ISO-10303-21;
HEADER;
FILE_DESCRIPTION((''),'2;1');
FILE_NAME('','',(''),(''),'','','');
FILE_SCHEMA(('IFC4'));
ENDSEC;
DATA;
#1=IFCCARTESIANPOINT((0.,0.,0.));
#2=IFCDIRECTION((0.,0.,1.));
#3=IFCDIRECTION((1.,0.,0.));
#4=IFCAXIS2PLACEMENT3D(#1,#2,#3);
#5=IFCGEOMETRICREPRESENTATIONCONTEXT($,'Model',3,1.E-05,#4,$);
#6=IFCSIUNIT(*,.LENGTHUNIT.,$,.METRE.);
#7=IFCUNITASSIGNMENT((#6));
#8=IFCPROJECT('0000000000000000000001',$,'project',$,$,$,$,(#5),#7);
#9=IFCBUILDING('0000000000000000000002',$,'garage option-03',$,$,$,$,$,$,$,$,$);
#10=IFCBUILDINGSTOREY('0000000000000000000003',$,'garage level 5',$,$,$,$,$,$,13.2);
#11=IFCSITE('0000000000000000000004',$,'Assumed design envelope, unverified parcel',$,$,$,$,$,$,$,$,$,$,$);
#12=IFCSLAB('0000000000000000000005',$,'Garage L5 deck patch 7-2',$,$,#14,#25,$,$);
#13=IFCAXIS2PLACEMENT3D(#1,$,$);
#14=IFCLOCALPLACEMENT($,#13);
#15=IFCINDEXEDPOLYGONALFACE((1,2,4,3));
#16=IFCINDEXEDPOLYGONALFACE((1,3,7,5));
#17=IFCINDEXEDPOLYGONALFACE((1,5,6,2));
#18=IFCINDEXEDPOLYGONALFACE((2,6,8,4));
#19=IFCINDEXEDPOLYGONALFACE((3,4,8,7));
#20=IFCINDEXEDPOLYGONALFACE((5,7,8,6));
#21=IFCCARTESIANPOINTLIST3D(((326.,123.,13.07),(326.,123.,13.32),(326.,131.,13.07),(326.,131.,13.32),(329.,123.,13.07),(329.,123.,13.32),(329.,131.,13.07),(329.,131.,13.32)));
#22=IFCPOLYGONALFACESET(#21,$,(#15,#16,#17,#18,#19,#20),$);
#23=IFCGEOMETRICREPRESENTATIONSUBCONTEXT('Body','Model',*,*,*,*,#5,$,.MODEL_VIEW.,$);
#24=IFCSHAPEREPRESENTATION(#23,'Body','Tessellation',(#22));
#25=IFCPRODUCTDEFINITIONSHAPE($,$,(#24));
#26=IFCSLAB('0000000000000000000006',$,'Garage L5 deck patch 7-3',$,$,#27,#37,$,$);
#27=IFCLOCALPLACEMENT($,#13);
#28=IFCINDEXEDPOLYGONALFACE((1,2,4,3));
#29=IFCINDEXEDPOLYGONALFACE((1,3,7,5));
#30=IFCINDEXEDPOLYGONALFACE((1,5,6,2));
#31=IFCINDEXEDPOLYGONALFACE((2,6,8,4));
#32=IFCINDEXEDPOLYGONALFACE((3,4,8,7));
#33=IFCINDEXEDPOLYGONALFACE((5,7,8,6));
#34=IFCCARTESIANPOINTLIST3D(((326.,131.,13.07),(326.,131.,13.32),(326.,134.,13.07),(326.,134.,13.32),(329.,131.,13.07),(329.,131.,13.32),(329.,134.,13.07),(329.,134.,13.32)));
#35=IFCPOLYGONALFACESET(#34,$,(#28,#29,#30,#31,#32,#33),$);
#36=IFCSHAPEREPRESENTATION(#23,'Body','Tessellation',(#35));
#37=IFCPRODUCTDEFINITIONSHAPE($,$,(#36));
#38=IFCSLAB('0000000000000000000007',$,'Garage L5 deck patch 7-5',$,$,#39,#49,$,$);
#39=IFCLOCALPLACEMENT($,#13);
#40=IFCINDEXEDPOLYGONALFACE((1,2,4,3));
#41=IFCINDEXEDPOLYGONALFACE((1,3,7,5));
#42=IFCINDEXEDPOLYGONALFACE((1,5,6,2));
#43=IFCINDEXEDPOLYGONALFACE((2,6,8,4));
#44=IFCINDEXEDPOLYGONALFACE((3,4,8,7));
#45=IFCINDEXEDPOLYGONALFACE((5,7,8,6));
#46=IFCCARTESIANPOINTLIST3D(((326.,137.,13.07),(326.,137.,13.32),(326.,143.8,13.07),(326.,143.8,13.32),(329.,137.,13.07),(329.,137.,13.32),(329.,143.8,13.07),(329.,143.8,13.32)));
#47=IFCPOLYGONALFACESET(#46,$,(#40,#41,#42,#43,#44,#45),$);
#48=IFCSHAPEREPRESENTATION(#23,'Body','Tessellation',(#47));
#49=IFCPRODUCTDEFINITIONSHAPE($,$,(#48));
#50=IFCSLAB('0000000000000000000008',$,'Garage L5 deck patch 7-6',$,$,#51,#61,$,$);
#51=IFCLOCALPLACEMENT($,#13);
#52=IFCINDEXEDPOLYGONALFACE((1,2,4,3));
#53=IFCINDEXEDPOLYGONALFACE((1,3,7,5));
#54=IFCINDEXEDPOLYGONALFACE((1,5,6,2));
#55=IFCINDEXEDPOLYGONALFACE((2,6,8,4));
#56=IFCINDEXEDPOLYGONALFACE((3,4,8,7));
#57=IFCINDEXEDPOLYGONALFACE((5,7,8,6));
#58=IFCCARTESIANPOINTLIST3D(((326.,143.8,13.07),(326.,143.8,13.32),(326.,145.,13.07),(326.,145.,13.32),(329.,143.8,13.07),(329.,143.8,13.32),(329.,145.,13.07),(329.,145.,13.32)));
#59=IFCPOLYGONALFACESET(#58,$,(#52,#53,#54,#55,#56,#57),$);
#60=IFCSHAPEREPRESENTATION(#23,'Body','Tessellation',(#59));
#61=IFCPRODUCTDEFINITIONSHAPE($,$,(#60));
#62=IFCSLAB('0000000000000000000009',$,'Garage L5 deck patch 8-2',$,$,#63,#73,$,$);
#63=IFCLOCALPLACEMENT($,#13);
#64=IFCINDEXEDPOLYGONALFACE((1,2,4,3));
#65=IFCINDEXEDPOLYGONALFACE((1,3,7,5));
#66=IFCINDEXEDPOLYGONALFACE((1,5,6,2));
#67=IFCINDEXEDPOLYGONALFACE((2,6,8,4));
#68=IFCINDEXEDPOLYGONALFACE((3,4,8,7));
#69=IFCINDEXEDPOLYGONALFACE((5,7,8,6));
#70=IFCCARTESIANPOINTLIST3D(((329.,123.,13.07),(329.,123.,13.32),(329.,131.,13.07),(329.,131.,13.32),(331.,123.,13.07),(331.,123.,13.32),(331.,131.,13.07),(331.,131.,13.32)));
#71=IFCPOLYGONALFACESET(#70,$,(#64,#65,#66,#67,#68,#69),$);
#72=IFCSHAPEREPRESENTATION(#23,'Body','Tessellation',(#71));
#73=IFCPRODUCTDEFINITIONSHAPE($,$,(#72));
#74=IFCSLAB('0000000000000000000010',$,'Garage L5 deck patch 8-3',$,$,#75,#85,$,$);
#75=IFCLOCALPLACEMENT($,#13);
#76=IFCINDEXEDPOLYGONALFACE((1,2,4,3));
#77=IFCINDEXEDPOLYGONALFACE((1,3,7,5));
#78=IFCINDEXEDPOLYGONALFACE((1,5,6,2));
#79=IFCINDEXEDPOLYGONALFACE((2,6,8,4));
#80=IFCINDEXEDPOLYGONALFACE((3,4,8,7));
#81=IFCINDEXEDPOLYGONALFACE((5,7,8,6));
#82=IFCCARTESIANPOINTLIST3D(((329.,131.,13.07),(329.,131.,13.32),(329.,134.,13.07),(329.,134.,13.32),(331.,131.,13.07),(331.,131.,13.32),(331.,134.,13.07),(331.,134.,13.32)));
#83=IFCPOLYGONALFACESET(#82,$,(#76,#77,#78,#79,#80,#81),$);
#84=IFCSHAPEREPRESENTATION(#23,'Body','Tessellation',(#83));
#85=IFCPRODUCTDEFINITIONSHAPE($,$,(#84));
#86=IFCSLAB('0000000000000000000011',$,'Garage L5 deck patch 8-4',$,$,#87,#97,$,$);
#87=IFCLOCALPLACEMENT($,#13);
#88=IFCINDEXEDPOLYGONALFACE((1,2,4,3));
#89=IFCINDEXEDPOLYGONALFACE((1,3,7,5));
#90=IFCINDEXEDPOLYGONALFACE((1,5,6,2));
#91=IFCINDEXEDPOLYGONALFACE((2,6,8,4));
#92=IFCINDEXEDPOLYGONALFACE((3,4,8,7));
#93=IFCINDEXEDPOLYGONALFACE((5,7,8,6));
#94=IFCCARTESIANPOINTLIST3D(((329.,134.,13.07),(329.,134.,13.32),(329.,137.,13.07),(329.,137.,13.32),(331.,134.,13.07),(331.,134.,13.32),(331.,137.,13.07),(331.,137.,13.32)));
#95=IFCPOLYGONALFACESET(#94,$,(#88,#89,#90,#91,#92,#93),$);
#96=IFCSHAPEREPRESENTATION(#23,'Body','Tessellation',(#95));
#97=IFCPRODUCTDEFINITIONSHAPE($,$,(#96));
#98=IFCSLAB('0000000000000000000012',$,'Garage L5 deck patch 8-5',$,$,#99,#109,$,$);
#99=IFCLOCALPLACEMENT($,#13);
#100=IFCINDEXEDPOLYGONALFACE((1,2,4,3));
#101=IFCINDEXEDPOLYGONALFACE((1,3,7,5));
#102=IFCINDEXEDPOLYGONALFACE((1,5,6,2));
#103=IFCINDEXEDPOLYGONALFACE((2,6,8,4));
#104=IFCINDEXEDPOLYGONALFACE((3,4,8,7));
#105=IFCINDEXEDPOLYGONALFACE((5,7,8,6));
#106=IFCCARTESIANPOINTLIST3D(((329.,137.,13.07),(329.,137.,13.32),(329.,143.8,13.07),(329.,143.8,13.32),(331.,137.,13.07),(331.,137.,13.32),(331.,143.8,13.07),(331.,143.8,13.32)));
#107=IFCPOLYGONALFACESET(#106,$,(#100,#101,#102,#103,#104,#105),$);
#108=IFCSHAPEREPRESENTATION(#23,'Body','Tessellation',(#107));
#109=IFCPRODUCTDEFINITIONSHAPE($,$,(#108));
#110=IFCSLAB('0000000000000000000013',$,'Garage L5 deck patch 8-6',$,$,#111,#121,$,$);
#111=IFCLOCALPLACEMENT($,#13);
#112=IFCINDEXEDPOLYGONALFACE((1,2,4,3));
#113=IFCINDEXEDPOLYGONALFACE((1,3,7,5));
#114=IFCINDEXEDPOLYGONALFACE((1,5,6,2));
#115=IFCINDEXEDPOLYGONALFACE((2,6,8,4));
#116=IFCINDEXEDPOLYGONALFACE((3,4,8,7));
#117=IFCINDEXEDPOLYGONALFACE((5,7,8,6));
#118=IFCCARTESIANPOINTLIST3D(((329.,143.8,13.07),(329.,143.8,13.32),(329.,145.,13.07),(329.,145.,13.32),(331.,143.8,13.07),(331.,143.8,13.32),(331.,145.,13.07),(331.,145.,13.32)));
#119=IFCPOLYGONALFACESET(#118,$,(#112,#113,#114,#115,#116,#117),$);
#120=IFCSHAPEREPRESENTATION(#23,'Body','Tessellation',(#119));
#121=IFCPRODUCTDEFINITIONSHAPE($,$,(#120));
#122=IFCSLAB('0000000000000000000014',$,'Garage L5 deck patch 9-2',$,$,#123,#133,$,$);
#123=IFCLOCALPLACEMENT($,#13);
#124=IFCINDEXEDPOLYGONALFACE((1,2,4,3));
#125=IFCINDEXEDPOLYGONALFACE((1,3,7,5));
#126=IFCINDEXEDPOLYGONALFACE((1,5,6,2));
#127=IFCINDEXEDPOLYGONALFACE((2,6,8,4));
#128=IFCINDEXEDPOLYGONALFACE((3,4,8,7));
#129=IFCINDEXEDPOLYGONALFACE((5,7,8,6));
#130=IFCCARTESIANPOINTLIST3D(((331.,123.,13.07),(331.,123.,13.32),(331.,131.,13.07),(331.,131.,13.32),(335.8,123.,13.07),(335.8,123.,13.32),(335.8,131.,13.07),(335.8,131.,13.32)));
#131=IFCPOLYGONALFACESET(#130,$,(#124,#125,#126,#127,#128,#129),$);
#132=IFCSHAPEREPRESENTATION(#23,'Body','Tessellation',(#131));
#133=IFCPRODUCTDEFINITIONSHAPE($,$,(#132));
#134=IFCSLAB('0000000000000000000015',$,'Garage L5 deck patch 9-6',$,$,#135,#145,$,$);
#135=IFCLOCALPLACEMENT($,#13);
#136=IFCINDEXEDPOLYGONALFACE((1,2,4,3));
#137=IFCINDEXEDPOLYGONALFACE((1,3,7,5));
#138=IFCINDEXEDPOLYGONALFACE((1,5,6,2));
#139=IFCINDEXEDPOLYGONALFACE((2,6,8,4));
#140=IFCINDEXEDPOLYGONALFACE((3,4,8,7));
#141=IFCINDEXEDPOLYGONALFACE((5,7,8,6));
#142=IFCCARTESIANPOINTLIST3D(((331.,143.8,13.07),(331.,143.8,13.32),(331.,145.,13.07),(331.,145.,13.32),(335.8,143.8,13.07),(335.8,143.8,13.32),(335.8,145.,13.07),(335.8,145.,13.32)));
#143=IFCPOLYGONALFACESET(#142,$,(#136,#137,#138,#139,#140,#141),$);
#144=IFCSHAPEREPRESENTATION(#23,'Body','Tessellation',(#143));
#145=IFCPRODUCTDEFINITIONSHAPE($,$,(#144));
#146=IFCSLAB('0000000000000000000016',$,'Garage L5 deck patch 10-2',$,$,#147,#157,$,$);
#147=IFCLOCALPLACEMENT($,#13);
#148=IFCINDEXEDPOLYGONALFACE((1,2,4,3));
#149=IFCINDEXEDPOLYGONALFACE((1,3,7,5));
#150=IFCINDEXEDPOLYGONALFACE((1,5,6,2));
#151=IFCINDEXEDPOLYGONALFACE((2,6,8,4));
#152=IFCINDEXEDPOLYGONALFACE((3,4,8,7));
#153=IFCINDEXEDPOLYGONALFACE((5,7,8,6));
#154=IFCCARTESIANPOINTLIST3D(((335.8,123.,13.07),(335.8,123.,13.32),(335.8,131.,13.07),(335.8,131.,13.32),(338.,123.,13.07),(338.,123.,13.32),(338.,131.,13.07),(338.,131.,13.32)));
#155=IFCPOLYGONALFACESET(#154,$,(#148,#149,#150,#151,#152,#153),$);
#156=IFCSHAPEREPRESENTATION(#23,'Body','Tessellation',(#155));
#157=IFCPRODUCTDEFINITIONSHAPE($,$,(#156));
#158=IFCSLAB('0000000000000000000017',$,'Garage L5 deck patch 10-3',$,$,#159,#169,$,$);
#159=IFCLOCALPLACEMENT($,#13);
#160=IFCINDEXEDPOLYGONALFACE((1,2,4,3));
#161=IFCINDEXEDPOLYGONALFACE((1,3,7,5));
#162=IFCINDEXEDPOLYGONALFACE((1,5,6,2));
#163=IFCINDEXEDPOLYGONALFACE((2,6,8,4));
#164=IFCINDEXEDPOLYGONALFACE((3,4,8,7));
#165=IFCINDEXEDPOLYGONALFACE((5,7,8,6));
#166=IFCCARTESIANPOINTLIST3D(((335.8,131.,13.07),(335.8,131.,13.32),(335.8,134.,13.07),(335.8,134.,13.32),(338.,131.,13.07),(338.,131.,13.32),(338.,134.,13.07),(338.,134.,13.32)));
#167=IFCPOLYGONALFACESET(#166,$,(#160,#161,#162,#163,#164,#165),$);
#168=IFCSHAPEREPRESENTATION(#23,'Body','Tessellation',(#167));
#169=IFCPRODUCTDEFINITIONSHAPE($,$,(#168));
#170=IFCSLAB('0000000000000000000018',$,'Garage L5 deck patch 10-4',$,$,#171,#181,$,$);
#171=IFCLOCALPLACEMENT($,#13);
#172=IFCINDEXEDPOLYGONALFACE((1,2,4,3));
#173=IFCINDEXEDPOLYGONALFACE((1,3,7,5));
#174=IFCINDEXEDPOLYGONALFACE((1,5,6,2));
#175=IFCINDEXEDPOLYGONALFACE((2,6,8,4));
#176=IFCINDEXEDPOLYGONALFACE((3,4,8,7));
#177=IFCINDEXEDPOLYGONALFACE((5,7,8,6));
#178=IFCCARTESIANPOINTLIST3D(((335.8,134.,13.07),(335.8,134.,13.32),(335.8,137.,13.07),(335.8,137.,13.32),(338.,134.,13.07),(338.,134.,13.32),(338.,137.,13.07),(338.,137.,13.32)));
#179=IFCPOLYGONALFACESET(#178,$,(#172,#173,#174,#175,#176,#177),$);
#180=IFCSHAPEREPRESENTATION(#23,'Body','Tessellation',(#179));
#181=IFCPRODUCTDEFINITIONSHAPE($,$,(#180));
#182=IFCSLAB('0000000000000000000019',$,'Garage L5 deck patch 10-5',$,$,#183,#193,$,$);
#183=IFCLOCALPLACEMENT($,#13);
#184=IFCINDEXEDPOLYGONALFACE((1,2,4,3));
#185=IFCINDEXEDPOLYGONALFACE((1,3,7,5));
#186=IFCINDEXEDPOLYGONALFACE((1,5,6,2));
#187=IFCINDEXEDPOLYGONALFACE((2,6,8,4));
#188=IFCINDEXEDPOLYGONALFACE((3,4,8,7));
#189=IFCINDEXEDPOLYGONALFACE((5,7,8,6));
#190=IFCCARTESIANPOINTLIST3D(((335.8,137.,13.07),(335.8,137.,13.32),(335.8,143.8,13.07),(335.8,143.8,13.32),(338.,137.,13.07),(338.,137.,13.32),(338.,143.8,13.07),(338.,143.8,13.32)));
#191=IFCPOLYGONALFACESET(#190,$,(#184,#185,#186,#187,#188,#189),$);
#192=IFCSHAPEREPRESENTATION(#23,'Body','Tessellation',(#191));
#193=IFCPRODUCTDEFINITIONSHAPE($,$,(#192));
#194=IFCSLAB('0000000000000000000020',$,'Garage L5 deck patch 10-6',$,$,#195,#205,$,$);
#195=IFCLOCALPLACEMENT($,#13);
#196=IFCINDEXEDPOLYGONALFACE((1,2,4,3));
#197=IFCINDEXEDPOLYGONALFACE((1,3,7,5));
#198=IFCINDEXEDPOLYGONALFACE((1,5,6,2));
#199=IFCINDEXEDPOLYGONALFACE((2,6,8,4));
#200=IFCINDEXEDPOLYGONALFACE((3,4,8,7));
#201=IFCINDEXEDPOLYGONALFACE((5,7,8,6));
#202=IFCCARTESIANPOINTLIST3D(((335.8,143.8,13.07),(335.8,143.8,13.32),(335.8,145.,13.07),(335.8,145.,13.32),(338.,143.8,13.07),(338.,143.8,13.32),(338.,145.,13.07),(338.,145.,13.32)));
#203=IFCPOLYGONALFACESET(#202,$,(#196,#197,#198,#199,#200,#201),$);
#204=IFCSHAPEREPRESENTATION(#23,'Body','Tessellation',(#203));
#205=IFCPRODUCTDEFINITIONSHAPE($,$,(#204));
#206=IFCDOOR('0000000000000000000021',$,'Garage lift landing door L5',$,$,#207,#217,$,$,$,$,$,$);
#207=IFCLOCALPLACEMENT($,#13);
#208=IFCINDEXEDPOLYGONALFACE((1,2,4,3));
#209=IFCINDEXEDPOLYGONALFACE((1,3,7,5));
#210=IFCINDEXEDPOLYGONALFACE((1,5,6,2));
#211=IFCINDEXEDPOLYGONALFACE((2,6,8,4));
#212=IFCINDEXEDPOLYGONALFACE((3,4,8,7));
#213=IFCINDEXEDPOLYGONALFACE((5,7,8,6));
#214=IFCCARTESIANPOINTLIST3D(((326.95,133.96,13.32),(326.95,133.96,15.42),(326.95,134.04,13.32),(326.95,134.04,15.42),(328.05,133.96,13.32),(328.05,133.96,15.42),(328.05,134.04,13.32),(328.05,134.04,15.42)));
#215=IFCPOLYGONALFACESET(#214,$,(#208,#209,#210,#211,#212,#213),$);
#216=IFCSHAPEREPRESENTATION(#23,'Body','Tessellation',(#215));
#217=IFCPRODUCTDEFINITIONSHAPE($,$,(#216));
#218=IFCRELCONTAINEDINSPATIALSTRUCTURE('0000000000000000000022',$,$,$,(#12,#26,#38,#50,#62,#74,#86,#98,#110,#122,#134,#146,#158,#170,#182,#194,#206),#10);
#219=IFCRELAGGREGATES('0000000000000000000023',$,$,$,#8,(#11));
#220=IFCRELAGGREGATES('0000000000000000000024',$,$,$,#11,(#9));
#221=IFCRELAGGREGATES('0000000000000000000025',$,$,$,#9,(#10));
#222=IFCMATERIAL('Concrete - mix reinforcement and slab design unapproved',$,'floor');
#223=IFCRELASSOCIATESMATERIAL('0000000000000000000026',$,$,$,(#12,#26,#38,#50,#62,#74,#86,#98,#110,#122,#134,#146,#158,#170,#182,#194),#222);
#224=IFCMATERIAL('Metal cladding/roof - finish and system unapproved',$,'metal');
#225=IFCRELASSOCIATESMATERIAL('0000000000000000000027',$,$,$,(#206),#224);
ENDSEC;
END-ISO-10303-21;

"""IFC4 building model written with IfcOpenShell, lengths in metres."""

from ifc_helpers import new_model, si_unit, frame, origin_with_axes, place, context, subcontext, project, spatial, rectangle, extrude, material, element, save


model = new_model("IFC4")

# Units and contexts
model_context = context("Model", 3, precision=1e-05, world=origin_with_axes())
body_context = subcontext(model_context, "Body", "Model", "MODEL_VIEW")
ifc_project = project(units=[si_unit("LENGTHUNIT", "METRE")], contexts=[model_context])

# Site, building, storey
site = spatial("IfcSite", under=ifc_project, Name="Assumed design envelope, unverified parcel")
building = spatial("IfcBuilding", under=site, Name="garage option-03")
storey = spatial("IfcBuildingStorey", under=building, Name="garage level 5", Elevation=13.2)

# Slabs
ifc_material_1 = material(Name="Concrete - mix reinforcement and slab design unapproved", Category="floor")
slab_1_placement = place(None, frame((327.5, 127.0, 13.07), z_axis=(0.0, 0.0, 1.0), x_axis=(1.0, 0.0, 0.0)))
element("IfcSlab", 1, at=slab_1_placement, inside=storey, material=ifc_material_1, Name="Garage L5 deck patch 7-2", context=body_context, shape_type="SweptSolid", body=[
    extrude(rectangle(XDim=3.0, YDim=8.0), origin_with_axes(), (0.0, 0.0, 1.0), 0.25),
])
slab_2_placement = place(None, frame((327.5, 132.5, 13.07), z_axis=(0.0, 0.0, 1.0), x_axis=(1.0, 0.0, 0.0)))
element("IfcSlab", 2, at=slab_2_placement, inside=storey, material=ifc_material_1, Name="Garage L5 deck patch 7-3", context=body_context, shape_type="SweptSolid", body=[
    extrude(rectangle(XDim=3.0, YDim=3.0), origin_with_axes(), (0.0, 0.0, 1.0), 0.25),
])
slab_3_placement = place(None, frame((327.5, 140.4, 13.07), z_axis=(0.0, 0.0, 1.0), x_axis=(1.0, 0.0, 0.0)))
element("IfcSlab", 3, at=slab_3_placement, inside=storey, material=ifc_material_1, Name="Garage L5 deck patch 7-5", context=body_context, shape_type="SweptSolid", body=[
    extrude(rectangle(XDim=3.0, YDim=6.8), origin_with_axes(), (0.0, 0.0, 1.0), 0.25),
])
slab_4_placement = place(None, frame((327.5, 144.4, 13.07), z_axis=(0.0, 0.0, 1.0), x_axis=(1.0, 0.0, 0.0)))
element("IfcSlab", 4, at=slab_4_placement, inside=storey, material=ifc_material_1, Name="Garage L5 deck patch 7-6", context=body_context, shape_type="SweptSolid", body=[
    extrude(rectangle(XDim=3.0, YDim=1.2), origin_with_axes(), (0.0, 0.0, 1.0), 0.25),
])
slab_5_placement = place(None, frame((330.0, 127.0, 13.07), z_axis=(0.0, 0.0, 1.0), x_axis=(1.0, 0.0, 0.0)))
element("IfcSlab", 5, at=slab_5_placement, inside=storey, material=ifc_material_1, Name="Garage L5 deck patch 8-2", context=body_context, shape_type="SweptSolid", body=[
    extrude(rectangle(XDim=2.0, YDim=8.0), origin_with_axes(), (0.0, 0.0, 1.0), 0.25),
])
for number, where, z_axis, x_axis, name in (
    (6, (330.0, 132.5, 13.07), (0.0, 0.0, 1.0), (1.0, 0.0, 0.0), "Garage L5 deck patch 8-3"),
    (7, (330.0, 135.5, 13.07), (0.0, 0.0, 1.0), (1.0, 0.0, 0.0), "Garage L5 deck patch 8-4"),
):
    element("IfcSlab", number, at=place(None, frame(where, z_axis=z_axis, x_axis=x_axis)), inside=storey, material=ifc_material_1, Name=name, context=body_context, shape_type="SweptSolid", body=[
        extrude(rectangle(XDim=2.0, YDim=3.0), origin_with_axes(), (0.0, 0.0, 1.0), 0.25),
    ])
slab_6_placement = place(None, frame((330.0, 140.4, 13.07), z_axis=(0.0, 0.0, 1.0), x_axis=(1.0, 0.0, 0.0)))
element("IfcSlab", 8, at=slab_6_placement, inside=storey, material=ifc_material_1, Name="Garage L5 deck patch 8-5", context=body_context, shape_type="SweptSolid", body=[
    extrude(rectangle(XDim=2.0, YDim=6.8), origin_with_axes(), (0.0, 0.0, 1.0), 0.25),
])
slab_7_placement = place(None, frame((330.0, 144.4, 13.07), z_axis=(0.0, 0.0, 1.0), x_axis=(1.0, 0.0, 0.0)))
element("IfcSlab", 9, at=slab_7_placement, inside=storey, material=ifc_material_1, Name="Garage L5 deck patch 8-6", context=body_context, shape_type="SweptSolid", body=[
    extrude(rectangle(XDim=2.0, YDim=1.2), origin_with_axes(), (0.0, 0.0, 1.0), 0.25),
])
slab_8_placement = place(None, frame((333.4, 127.0, 13.07), z_axis=(0.0, 0.0, 1.0), x_axis=(1.0, 0.0, 0.0)))
element("IfcSlab", 10, at=slab_8_placement, inside=storey, material=ifc_material_1, Name="Garage L5 deck patch 9-2", context=body_context, shape_type="SweptSolid", body=[
    extrude(rectangle(XDim=4.8, YDim=8.0), origin_with_axes(), (0.0, 0.0, 1.0), 0.25),
])
slab_9_placement = place(None, frame((333.4, 144.4, 13.07), z_axis=(0.0, 0.0, 1.0), x_axis=(1.0, 0.0, 0.0)))
element("IfcSlab", 11, at=slab_9_placement, inside=storey, material=ifc_material_1, Name="Garage L5 deck patch 9-6", context=body_context, shape_type="SweptSolid", body=[
    extrude(rectangle(XDim=4.8, YDim=1.2), origin_with_axes(), (0.0, 0.0, 1.0), 0.25),
])
slab_10_placement = place(None, frame((336.9, 127.0, 13.07), z_axis=(0.0, 0.0, 1.0), x_axis=(1.0, 0.0, 0.0)))
element("IfcSlab", 12, at=slab_10_placement, inside=storey, material=ifc_material_1, Name="Garage L5 deck patch 10-2", context=body_context, shape_type="SweptSolid", body=[
    extrude(rectangle(XDim=2.2, YDim=8.0), origin_with_axes(), (0.0, 0.0, 1.0), 0.25),
])
for number, where, z_axis, x_axis, name in (
    (13, (336.9, 132.5, 13.07), (0.0, 0.0, 1.0), (1.0, 0.0, 0.0), "Garage L5 deck patch 10-3"),
    (14, (336.9, 135.5, 13.07), (0.0, 0.0, 1.0), (1.0, 0.0, 0.0), "Garage L5 deck patch 10-4"),
):
    element("IfcSlab", number, at=place(None, frame(where, z_axis=z_axis, x_axis=x_axis)), inside=storey, material=ifc_material_1, Name=name, context=body_context, shape_type="SweptSolid", body=[
        extrude(rectangle(XDim=2.2, YDim=3.0), origin_with_axes(), (0.0, 0.0, 1.0), 0.25),
    ])
slab_11_placement = place(None, frame((336.9, 140.4, 13.07), z_axis=(0.0, 0.0, 1.0), x_axis=(1.0, 0.0, 0.0)))
element("IfcSlab", 15, at=slab_11_placement, inside=storey, material=ifc_material_1, Name="Garage L5 deck patch 10-5", context=body_context, shape_type="SweptSolid", body=[
    extrude(rectangle(XDim=2.2, YDim=6.8), origin_with_axes(), (0.0, 0.0, 1.0), 0.25),
])
slab_12_placement = place(None, frame((336.9, 144.4, 13.07), z_axis=(0.0, 0.0, 1.0), x_axis=(1.0, 0.0, 0.0)))
element("IfcSlab", 16, at=slab_12_placement, inside=storey, material=ifc_material_1, Name="Garage L5 deck patch 10-6", context=body_context, shape_type="SweptSolid", body=[
    extrude(rectangle(XDim=2.2, YDim=1.2), origin_with_axes(), (0.0, 0.0, 1.0), 0.25),
])

# Door
ifc_material_2 = material(Name="Metal cladding/roof - finish and system unapproved", Category="metal")
door_placement = place(None, frame((327.5, 134.0, 13.32), z_axis=(0.0, 0.0, 1.0), x_axis=(1.0, 0.0, 0.0)))
element("IfcDoor", 17, at=door_placement, inside=storey, material=ifc_material_2, Name="Garage lift landing door L5", context=body_context, shape_type="SweptSolid", body=[
    extrude(rectangle(XDim=1.1, YDim=0.08), origin_with_axes(), (0.0, 0.0, 1.0), 2.1),
])

save(model, "model.ifc")
